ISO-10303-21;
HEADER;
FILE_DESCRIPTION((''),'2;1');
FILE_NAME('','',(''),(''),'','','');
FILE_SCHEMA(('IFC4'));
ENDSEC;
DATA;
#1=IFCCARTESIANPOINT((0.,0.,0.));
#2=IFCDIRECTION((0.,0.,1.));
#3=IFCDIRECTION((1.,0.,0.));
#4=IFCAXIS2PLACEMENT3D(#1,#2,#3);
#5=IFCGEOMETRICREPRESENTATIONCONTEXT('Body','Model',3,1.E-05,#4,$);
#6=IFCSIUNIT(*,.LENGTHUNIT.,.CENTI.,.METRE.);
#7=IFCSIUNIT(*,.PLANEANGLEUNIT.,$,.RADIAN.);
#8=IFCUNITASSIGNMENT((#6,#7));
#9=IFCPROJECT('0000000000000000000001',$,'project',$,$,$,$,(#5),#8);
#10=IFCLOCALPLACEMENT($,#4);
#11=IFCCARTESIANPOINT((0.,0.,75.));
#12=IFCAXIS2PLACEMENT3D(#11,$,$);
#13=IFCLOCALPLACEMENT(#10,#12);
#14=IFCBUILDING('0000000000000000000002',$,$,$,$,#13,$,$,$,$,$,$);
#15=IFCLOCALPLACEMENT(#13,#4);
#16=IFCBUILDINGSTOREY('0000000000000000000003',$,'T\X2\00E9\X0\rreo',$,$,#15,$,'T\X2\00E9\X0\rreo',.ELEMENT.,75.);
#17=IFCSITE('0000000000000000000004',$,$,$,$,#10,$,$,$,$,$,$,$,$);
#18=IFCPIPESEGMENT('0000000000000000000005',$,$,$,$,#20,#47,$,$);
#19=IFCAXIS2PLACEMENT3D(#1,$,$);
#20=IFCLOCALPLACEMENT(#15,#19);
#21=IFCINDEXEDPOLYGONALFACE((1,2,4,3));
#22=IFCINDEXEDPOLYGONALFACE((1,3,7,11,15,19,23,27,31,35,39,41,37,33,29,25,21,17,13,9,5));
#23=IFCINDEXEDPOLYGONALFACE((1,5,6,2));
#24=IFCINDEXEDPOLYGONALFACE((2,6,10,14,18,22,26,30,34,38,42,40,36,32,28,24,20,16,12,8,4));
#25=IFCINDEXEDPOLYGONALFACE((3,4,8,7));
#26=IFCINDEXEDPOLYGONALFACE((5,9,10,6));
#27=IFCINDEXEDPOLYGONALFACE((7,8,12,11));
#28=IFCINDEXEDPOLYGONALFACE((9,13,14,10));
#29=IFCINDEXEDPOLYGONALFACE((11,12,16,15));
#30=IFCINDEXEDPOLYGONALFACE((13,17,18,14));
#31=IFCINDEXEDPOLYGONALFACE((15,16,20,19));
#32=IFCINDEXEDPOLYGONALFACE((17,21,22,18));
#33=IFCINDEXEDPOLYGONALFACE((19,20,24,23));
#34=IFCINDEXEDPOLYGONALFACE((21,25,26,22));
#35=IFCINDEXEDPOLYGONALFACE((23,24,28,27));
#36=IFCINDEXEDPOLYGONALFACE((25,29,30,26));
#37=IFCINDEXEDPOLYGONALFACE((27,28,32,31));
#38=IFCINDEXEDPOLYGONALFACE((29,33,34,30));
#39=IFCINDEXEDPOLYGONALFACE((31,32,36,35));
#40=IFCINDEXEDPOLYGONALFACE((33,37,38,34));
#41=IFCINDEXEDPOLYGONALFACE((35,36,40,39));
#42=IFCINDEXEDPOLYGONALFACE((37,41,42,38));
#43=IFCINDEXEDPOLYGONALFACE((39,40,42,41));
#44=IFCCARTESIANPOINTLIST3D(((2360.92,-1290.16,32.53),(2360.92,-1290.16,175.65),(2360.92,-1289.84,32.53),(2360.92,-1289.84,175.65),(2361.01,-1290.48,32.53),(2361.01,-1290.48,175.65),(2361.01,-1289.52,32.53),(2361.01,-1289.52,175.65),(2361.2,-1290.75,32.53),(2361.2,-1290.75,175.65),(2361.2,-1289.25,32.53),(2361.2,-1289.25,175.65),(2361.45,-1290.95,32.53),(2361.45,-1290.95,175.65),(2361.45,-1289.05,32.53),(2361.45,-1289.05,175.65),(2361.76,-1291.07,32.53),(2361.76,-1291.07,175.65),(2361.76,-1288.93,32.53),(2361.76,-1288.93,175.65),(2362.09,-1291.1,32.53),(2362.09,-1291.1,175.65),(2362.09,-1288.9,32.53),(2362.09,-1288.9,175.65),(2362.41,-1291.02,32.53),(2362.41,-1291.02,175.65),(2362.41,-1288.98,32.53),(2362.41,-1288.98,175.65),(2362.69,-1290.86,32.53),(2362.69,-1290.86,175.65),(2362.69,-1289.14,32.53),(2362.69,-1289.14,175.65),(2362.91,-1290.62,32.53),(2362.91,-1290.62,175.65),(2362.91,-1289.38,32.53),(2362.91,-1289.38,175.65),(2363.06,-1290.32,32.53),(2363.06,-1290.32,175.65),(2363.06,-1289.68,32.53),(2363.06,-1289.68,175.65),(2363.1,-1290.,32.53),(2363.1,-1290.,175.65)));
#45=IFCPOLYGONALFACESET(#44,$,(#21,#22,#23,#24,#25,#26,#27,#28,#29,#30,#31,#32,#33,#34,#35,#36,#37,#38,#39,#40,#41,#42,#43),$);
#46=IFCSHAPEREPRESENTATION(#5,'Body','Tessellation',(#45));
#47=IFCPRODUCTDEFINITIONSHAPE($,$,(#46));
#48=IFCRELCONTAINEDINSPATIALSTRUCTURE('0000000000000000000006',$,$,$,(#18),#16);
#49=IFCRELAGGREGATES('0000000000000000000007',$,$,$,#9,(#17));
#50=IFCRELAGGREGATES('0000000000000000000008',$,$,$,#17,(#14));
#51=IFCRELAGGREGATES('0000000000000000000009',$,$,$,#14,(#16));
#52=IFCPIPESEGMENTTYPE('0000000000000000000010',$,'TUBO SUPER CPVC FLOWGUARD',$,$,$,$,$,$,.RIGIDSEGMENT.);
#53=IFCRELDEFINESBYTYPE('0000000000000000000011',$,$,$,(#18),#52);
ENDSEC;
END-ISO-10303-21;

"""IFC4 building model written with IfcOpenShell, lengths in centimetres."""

from ifc_helpers import new_model, si_unit, frame, origin_with_axes, origin_2d_with_axis, place, context, project, spatial, circle, extrude, type_object, element, save


model = new_model("IFC4")

# Units and contexts
model_context = context("Model", 3, precision=1e-05, world=origin_with_axes(), identifier="Body")
ifc_project = project(units=[si_unit("LENGTHUNIT", "METRE", prefix="CENTI"), si_unit("PLANEANGLEUNIT", "RADIAN")], contexts=[model_context])

# Site, building, storey
site_placement = place(None, origin_with_axes())
site = spatial("IfcSite", under=ifc_project, at=site_placement)
building_placement = place(site_placement, frame((0.0, 0.0, 75.0)))
building = spatial("IfcBuilding", under=site, at=building_placement)
storey_placement = place(building_placement, origin_with_axes())
storey = spatial("IfcBuildingStorey", under=building, at=storey_placement, Name="Térreo", LongName="Térreo", CompositionType="ELEMENT", Elevation=75.0)

# Pipe segment
pipe_segment_type_1 = type_object("IfcPipeSegmentType", Name="TUBO SUPER CPVC FLOWGUARD", PredefinedType="RIGIDSEGMENT")
pipe_segment_1_placement = place(storey_placement, frame((2362.0, -1290.0, 175.65), z_axis=(0.0, 0.0, 1.0), x_axis=(1.0, 0.0, 0.0)))
element("IfcPipeSegment", 1, at=pipe_segment_1_placement, inside=storey, type_object=pipe_segment_type_1, context=model_context, shape_type="SolidModel", body=[
    extrude(circle(Radius=1.1, at=origin_2d_with_axis()), frame((0.0, 0.0, 0.0), z_axis=(0.0, 0.0, -1.0), x_axis=(1.0, 0.0, 0.0)), (0.0, 0.0, 1.0), 143.12),
])

save(model, "model.ifc")
